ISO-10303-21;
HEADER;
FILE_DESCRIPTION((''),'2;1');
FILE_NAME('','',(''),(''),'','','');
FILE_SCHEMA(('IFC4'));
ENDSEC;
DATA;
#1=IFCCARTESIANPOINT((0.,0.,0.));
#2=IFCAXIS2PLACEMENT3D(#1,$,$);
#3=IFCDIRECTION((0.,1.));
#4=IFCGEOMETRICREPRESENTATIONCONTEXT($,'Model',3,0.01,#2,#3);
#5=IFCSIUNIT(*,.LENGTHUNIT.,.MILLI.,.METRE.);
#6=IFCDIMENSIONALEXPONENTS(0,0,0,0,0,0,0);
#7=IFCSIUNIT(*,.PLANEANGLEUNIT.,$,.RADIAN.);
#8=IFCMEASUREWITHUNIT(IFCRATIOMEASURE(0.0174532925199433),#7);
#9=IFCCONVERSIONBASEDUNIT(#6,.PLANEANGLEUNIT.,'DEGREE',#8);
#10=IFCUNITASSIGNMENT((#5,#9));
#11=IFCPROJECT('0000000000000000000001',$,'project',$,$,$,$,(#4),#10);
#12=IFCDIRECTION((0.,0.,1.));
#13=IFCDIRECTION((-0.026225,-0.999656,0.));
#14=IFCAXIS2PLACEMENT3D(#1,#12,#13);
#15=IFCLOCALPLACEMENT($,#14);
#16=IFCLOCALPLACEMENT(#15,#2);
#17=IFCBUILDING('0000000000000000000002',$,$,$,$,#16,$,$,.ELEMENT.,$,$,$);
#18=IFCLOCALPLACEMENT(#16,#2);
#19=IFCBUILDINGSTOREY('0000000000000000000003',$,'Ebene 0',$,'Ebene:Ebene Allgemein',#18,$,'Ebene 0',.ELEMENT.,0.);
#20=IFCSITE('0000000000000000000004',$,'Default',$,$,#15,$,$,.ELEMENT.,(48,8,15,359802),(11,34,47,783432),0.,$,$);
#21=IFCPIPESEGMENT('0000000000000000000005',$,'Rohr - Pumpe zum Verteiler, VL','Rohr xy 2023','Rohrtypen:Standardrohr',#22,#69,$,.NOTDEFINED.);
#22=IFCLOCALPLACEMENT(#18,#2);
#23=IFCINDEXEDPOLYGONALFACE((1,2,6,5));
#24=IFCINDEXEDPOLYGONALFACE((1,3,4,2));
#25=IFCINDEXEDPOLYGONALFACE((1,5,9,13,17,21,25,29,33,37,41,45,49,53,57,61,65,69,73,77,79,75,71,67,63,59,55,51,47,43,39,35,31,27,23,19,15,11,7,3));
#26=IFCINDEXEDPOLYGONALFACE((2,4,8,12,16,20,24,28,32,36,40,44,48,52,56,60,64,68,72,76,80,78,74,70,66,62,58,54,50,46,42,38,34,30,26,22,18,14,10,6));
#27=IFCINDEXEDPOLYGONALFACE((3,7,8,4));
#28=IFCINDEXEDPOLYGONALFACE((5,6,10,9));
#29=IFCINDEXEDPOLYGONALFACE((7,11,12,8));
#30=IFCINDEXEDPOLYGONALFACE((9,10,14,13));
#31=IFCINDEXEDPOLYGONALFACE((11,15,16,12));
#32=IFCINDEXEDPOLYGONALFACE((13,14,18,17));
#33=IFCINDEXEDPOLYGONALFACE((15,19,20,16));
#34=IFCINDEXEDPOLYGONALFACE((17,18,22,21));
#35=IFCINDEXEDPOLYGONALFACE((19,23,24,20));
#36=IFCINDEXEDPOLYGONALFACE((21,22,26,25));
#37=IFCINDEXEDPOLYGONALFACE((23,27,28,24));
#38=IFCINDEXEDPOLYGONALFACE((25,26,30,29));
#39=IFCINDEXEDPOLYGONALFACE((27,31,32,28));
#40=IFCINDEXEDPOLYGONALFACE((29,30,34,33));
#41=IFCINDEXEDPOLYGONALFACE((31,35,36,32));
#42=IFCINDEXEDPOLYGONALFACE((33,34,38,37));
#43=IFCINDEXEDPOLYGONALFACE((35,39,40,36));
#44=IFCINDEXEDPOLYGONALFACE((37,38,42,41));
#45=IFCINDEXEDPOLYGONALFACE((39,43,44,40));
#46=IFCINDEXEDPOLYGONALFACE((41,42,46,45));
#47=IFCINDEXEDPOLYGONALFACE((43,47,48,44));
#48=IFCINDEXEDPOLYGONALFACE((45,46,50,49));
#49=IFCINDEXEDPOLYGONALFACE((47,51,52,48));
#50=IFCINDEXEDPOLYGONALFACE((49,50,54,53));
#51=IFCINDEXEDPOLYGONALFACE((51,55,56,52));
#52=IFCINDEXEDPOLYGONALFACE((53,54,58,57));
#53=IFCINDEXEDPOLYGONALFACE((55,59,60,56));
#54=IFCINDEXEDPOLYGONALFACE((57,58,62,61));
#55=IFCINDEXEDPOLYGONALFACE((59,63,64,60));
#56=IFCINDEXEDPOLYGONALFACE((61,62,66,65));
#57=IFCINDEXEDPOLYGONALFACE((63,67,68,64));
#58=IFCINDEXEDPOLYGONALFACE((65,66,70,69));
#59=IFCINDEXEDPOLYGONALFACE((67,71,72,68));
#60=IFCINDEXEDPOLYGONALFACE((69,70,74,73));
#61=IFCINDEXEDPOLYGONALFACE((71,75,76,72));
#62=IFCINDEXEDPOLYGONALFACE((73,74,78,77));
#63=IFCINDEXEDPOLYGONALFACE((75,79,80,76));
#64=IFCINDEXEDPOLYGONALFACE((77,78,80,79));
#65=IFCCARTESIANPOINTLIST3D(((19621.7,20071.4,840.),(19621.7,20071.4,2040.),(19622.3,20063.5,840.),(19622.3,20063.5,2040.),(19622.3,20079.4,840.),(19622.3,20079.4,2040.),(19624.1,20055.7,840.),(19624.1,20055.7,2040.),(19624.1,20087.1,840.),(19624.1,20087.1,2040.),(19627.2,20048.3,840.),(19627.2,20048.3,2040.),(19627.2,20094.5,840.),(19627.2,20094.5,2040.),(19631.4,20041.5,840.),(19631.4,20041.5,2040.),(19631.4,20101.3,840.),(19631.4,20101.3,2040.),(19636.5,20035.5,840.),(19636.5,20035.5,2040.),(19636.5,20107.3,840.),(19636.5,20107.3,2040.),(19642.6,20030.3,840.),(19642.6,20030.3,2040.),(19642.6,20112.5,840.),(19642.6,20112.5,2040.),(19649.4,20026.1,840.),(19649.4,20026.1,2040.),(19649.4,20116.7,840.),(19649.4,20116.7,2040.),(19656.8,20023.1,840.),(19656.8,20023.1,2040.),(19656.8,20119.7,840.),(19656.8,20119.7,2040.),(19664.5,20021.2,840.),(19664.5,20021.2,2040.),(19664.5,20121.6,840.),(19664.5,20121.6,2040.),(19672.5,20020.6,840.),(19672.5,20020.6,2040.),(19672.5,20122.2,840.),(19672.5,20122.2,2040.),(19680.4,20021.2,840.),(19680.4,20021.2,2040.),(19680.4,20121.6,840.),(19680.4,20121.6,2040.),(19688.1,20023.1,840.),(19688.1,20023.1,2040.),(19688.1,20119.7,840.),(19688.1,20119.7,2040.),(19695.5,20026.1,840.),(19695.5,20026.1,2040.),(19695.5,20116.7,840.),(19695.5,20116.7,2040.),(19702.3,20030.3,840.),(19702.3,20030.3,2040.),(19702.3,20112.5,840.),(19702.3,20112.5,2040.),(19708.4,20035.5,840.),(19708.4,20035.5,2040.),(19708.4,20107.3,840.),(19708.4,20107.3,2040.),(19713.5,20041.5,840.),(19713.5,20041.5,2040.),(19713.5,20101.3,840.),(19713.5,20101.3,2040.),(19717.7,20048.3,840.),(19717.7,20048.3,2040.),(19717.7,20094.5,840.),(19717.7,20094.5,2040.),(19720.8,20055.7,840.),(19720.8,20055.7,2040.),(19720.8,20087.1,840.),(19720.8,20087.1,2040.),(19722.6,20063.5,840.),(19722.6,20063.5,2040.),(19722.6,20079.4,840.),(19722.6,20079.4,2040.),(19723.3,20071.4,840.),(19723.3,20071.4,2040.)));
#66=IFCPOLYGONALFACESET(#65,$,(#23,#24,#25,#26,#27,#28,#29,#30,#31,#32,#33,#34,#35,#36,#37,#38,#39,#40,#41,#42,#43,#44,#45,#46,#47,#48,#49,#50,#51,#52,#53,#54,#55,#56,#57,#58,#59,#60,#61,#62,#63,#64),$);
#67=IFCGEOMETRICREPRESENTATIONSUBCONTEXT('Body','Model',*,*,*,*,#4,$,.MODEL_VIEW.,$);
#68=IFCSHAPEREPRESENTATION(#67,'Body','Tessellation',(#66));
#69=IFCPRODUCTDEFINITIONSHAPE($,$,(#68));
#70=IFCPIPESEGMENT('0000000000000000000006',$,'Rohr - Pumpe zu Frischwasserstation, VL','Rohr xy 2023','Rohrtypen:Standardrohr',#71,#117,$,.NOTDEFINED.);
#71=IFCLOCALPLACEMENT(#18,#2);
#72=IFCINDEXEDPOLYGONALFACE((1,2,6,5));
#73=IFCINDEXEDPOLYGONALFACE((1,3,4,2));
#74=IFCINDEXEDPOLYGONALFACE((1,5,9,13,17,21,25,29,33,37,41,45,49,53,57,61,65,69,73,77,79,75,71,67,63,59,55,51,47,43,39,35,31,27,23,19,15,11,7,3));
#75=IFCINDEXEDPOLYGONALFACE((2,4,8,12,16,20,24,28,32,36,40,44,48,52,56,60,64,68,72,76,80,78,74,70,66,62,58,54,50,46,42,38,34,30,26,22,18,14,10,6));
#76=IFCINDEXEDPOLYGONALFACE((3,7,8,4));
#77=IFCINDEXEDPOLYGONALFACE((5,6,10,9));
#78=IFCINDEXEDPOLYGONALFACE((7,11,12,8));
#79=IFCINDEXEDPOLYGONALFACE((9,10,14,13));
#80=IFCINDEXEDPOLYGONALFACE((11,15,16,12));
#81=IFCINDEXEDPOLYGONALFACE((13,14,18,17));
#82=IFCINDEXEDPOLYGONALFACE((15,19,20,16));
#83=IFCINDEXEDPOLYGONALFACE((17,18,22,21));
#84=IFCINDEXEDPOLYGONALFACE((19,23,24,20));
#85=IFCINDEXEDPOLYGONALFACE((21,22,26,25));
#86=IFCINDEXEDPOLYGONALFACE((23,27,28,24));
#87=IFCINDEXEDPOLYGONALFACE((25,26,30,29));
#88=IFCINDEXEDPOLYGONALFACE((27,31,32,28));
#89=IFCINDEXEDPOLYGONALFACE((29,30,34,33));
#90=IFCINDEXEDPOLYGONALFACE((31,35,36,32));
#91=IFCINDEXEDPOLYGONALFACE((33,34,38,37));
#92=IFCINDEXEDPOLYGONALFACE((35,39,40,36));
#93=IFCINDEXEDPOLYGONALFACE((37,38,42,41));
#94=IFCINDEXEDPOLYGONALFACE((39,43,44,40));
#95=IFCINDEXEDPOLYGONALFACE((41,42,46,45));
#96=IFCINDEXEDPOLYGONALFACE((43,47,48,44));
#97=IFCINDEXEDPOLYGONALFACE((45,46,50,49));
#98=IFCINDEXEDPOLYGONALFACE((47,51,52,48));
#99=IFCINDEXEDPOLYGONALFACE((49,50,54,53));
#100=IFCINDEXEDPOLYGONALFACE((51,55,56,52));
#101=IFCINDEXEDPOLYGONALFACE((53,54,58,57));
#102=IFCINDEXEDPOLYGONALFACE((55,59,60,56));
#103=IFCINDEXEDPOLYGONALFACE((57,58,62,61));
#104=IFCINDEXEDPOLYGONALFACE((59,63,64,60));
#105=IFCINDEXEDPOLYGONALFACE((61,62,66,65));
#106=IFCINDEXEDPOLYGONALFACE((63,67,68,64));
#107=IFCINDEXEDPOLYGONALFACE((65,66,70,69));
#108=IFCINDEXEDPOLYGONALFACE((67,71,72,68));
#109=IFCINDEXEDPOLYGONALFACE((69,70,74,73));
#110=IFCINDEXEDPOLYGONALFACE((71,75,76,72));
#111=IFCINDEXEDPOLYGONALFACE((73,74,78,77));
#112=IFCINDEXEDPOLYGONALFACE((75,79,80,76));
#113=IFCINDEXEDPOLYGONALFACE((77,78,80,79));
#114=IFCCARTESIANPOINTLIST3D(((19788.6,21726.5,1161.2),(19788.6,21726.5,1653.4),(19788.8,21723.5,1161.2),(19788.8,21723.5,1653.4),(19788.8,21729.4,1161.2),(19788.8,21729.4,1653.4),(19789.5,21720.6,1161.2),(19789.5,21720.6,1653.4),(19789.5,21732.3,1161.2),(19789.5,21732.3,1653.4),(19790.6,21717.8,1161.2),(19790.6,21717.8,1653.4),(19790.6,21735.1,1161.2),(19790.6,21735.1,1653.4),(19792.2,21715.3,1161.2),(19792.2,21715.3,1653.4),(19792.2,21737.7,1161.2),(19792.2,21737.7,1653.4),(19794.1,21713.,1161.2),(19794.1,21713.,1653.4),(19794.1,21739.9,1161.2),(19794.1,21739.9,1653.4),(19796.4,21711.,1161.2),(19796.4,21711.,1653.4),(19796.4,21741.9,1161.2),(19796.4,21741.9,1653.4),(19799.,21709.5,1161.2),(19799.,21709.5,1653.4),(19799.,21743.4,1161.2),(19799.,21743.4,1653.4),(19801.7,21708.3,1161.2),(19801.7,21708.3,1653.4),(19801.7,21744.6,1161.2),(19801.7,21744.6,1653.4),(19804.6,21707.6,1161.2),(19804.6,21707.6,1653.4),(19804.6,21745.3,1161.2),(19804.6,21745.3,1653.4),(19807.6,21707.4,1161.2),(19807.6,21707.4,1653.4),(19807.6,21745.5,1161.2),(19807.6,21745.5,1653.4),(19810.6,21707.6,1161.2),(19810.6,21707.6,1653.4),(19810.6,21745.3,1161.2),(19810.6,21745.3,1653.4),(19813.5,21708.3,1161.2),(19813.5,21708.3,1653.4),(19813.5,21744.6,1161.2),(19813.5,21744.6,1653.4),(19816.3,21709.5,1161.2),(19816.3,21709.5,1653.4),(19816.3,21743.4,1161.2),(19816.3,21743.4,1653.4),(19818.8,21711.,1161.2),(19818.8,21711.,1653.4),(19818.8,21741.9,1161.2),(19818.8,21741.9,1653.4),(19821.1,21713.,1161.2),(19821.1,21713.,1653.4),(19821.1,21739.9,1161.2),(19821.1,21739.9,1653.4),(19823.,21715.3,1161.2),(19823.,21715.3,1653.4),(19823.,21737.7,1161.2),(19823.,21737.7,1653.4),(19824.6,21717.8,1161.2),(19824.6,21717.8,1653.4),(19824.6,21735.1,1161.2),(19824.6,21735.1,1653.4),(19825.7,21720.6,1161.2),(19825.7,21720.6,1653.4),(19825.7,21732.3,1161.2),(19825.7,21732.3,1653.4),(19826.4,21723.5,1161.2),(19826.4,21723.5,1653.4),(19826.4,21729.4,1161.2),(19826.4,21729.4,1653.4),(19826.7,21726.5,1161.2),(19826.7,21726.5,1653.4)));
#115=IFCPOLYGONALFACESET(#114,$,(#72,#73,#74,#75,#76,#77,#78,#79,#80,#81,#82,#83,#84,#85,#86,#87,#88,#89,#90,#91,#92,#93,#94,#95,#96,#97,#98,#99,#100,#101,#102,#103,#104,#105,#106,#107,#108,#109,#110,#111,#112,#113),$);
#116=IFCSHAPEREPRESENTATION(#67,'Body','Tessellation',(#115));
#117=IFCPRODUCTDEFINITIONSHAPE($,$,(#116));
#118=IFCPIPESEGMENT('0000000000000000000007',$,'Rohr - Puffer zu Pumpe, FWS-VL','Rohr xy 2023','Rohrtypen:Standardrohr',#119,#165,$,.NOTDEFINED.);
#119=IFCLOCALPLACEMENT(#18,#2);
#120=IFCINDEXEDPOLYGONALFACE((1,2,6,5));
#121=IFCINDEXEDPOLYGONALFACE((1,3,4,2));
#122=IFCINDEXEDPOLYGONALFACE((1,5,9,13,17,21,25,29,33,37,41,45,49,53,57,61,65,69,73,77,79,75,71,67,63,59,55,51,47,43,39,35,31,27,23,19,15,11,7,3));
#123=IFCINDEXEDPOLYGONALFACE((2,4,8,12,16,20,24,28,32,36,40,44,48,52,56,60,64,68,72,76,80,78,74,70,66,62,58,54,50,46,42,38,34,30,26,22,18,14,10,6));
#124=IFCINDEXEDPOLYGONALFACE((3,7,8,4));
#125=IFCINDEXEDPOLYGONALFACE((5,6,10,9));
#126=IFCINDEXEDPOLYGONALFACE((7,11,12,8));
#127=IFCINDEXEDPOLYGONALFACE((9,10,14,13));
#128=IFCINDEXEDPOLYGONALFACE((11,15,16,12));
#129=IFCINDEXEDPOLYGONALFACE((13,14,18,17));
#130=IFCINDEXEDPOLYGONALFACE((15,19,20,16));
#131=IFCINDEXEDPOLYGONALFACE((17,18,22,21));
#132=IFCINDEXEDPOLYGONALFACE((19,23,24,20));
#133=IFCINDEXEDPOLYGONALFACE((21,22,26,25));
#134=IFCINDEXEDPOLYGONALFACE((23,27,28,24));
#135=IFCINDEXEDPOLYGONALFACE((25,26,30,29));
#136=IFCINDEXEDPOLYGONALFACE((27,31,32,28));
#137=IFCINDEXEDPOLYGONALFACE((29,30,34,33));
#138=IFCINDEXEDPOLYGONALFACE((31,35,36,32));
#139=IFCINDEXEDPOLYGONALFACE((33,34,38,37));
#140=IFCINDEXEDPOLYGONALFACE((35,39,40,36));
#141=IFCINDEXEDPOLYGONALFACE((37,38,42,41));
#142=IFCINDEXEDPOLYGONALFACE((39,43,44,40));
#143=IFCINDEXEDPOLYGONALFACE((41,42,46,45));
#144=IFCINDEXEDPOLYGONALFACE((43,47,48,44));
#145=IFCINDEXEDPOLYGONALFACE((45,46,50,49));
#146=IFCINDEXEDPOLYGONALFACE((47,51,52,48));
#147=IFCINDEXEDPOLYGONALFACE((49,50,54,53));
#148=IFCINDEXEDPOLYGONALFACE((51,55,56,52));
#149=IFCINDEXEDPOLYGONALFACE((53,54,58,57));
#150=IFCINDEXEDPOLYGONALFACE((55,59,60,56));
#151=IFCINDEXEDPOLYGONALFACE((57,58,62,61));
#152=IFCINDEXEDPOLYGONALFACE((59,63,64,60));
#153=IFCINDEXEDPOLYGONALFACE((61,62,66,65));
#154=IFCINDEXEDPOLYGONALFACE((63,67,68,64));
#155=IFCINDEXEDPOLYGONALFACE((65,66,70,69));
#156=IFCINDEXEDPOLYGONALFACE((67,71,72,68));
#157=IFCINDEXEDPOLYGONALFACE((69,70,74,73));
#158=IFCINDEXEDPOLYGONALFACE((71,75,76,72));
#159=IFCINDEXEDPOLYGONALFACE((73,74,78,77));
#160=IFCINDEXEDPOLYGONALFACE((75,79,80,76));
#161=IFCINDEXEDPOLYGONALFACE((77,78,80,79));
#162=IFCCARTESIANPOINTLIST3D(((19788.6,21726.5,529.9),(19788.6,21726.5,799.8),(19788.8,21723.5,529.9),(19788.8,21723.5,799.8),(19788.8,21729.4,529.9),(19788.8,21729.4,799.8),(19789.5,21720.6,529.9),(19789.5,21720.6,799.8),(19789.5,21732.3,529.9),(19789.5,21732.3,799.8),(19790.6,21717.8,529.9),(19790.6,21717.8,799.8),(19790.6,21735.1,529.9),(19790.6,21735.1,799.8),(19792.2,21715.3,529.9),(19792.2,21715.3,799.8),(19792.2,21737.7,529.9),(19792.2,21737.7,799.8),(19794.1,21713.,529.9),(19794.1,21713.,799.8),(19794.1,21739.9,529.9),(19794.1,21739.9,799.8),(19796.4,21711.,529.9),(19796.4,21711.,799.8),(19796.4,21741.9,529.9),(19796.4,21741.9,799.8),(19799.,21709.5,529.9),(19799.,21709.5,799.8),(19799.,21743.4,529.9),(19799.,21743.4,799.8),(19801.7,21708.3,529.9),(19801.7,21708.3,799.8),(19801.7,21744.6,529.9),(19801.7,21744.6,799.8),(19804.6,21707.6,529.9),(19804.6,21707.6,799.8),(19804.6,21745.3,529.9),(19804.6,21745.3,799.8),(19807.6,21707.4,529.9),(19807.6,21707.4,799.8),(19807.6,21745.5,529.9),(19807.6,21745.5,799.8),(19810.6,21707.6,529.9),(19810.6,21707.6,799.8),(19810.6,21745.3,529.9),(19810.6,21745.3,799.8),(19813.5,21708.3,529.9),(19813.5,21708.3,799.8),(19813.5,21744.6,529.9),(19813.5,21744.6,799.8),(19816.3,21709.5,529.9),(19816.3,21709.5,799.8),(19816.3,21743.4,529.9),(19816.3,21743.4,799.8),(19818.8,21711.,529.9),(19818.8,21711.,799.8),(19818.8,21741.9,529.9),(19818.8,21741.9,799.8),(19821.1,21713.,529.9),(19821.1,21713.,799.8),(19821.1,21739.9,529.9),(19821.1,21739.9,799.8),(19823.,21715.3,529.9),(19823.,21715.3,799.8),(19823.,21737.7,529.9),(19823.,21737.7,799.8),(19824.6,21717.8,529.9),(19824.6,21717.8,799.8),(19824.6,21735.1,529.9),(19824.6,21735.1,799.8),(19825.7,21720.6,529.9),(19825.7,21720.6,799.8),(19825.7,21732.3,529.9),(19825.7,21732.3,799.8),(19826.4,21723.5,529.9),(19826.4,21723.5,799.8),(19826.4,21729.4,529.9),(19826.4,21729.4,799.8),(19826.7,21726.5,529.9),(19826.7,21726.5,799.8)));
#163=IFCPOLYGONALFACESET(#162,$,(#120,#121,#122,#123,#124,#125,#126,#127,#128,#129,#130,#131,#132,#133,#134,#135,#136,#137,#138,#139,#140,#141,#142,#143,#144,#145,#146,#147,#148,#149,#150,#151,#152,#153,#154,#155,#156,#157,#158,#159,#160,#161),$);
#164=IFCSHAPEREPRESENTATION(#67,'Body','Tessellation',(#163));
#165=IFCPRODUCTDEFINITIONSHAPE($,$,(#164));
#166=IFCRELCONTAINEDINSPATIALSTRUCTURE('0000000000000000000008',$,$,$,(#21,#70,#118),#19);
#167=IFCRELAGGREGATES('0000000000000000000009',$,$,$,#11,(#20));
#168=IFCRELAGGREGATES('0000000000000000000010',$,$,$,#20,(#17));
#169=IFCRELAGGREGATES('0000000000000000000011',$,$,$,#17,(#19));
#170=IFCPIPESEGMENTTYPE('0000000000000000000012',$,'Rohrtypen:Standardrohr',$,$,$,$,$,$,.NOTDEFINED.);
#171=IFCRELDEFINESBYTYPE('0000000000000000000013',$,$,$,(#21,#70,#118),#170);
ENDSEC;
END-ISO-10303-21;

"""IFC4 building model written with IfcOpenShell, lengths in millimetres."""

from ifc_helpers import new_model, entity, si_unit, converted_unit, direction, frame, origin, place, context, subcontext, project, spatial, indexed_curve, outline, extrude, type_object, element, save


model = new_model("IFC4")

# Units and contexts
model_context = context("Model", 3, precision=0.01, world=origin(), true_north=direction((0.0, 1.0)))
body_context = subcontext(model_context, "Body", "Model", "MODEL_VIEW")
ifc_project = project(units=[si_unit("LENGTHUNIT", "METRE", prefix="MILLI"), converted_unit("PLANEANGLEUNIT", "DEGREE", entity("IfcRatioMeasure", 0.0174532925199433), si_unit("PLANEANGLEUNIT", "RADIAN"), dimensions=[0, 0, 0, 0, 0, 0, 0])], contexts=[model_context])

# Site, building, storey
site_placement = place(None, frame((0.0, 0.0, 0.0), z_axis=(0.0, 0.0, 1.0), x_axis=(-0.026225, -0.999656, 0.0)))
site = spatial("IfcSite", under=ifc_project, at=site_placement, Name="Default", CompositionType="ELEMENT", RefLatitude=(48, 8, 15, 359802), RefLongitude=(11, 34, 47, 783432), RefElevation=0.0)
building_placement = place(site_placement, origin())
building = spatial("IfcBuilding", under=site, at=building_placement, CompositionType="ELEMENT")
storey_placement = place(building_placement, origin())
storey = spatial("IfcBuildingStorey", under=building, at=storey_placement, Name="Ebene 0", ObjectType="Ebene:Ebene Allgemein", LongName="Ebene 0", CompositionType="ELEMENT", Elevation=0.0)

# Pipe segments
pipe_segment_type = type_object("IfcPipeSegmentType", Name="Rohrtypen:Standardrohr", PredefinedType="NOTDEFINED")
pipe_segment_1_placement = place(storey_placement, origin())
element("IfcPipeSegment", 1, at=pipe_segment_1_placement, inside=storey, type_object=pipe_segment_type, Name="Rohr - Pumpe zum Verteiler, VL", Description="Rohr xy 2023", ObjectType="Rohrtypen:Standardrohr", PredefinedType="NOTDEFINED", context=body_context, shape_type="SweptSolid", body=[
    extrude(outline(indexed_curve([(50.8, 0.0), (50.2, 7.9), (48.3, 15.7), (45.3, 23.1), (41.1, 29.9), (35.9, 35.9), (29.9, 41.1), (23.1, 45.3), (15.7, 48.3), (7.9, 50.2), (0.0, 50.8), (-7.9, 50.2), (-15.7, 48.3), (-23.1, 45.3), (-29.9, 41.1), (-35.9, 35.9), (-41.1, 29.9), (-45.3, 23.1), (-48.3, 15.7), (-50.2, 7.9), (-50.8, 0.0), (-50.2, -7.9), (-48.3, -15.7), (-45.3, -23.1), (-41.1, -29.9), (-35.9, -35.9), (-29.9, -41.1), (-23.1, -45.3), (-15.7, -48.3), (-7.9, -50.2), (0.0, -50.8), (7.9, -50.2), (15.7, -48.3), (23.1, -45.3), (29.9, -41.1), (35.9, -35.9), (41.1, -29.9), (45.3, -23.1), (48.3, -15.7), (50.2, -7.9), (50.8, 0.0)], self_intersect=False)), frame((19672.5, 20071.4, 840.0), z_axis=(0.0, 0.0, 1.0), x_axis=(-1.0, 0.0, 0.0)), (0.0, 0.0, 1.0), 1200.0),
])
pipe_segment_2_placement = place(storey_placement, origin())
element("IfcPipeSegment", 2, at=pipe_segment_2_placement, inside=storey, type_object=pipe_segment_type, Name="Rohr - Pumpe zu Frischwasserstation, VL", Description="Rohr xy 2023", ObjectType="Rohrtypen:Standardrohr", PredefinedType="NOTDEFINED", context=body_context, shape_type="SweptSolid", body=[
    extrude(outline(indexed_curve([(19.1, 0.0), (18.8, 3.0), (18.1, 5.9), (17.0, 8.6), (15.4, 11.2), (13.5, 13.5), (11.2, 15.4), (8.6, 17.0), (5.9, 18.1), (3.0, 18.8), (0.0, 19.0), (-3.0, 18.8), (-5.9, 18.1), (-8.6, 17.0), (-11.2, 15.4), (-13.5, 13.5), (-15.4, 11.2), (-17.0, 8.6), (-18.1, 5.9), (-18.8, 3.0), (-19.1, 0.0), (-18.8, -3.0), (-18.1, -5.9), (-17.0, -8.6), (-15.4, -11.2), (-13.5, -13.5), (-11.2, -15.4), (-8.6, -17.0), (-5.9, -18.1), (-3.0, -18.8), (0.0, -19.0), (3.0, -18.8), (5.9, -18.1), (8.6, -17.0), (11.2, -15.4), (13.5, -13.5), (15.4, -11.2), (17.0, -8.6), (18.1, -5.9), (18.8, -3.0), (19.1, 0.0)], self_intersect=False)), frame((19807.6, 21726.5, 1161.2), z_axis=(0.000002, 0.000002, 1.0), x_axis=(-1.0, 0.0, 0.000002)), (0.0, 0.0, 1.0), 492.1),
])
pipe_segment_3_placement = place(storey_placement, origin())
element("IfcPipeSegment", 3, at=pipe_segment_3_placement, inside=storey, type_object=pipe_segment_type, Name="Rohr - Puffer zu Pumpe, FWS-VL", Description="Rohr xy 2023", ObjectType="Rohrtypen:Standardrohr", PredefinedType="NOTDEFINED", context=body_context, shape_type="SweptSolid", body=[
    extrude(outline(indexed_curve([(19.1, 0.0), (18.8, 3.0), (18.1, 5.9), (17.0, 8.6), (15.4, 11.2), (13.5, 13.5), (11.2, 15.4), (8.6, 17.0), (5.9, 18.1), (3.0, 18.8), (0.0, 19.0), (-3.0, 18.8), (-5.9, 18.1), (-8.6, 17.0), (-11.2, 15.4), (-13.5, 13.5), (-15.4, 11.2), (-17.0, 8.6), (-18.1, 5.9), (-18.8, 3.0), (-19.1, 0.0), (-18.8, -3.0), (-18.1, -5.9), (-17.0, -8.6), (-15.4, -11.2), (-13.5, -13.5), (-11.2, -15.4), (-8.6, -17.0), (-5.9, -18.1), (-3.0, -18.8), (0.0, -19.0), (3.0, -18.8), (5.9, -18.1), (8.6, -17.0), (11.2, -15.4), (13.5, -13.5), (15.4, -11.2), (17.0, -8.6), (18.1, -5.9), (18.8, -3.0), (19.1, 0.0)], self_intersect=False)), frame((19807.6, 21726.5, 529.9), z_axis=(0.000002, 0.000002, 1.0), x_axis=(-1.0, 0.0, 0.000002)), (0.0, 0.0, 1.0), 269.9),
])

save(model, "model.ifc")
